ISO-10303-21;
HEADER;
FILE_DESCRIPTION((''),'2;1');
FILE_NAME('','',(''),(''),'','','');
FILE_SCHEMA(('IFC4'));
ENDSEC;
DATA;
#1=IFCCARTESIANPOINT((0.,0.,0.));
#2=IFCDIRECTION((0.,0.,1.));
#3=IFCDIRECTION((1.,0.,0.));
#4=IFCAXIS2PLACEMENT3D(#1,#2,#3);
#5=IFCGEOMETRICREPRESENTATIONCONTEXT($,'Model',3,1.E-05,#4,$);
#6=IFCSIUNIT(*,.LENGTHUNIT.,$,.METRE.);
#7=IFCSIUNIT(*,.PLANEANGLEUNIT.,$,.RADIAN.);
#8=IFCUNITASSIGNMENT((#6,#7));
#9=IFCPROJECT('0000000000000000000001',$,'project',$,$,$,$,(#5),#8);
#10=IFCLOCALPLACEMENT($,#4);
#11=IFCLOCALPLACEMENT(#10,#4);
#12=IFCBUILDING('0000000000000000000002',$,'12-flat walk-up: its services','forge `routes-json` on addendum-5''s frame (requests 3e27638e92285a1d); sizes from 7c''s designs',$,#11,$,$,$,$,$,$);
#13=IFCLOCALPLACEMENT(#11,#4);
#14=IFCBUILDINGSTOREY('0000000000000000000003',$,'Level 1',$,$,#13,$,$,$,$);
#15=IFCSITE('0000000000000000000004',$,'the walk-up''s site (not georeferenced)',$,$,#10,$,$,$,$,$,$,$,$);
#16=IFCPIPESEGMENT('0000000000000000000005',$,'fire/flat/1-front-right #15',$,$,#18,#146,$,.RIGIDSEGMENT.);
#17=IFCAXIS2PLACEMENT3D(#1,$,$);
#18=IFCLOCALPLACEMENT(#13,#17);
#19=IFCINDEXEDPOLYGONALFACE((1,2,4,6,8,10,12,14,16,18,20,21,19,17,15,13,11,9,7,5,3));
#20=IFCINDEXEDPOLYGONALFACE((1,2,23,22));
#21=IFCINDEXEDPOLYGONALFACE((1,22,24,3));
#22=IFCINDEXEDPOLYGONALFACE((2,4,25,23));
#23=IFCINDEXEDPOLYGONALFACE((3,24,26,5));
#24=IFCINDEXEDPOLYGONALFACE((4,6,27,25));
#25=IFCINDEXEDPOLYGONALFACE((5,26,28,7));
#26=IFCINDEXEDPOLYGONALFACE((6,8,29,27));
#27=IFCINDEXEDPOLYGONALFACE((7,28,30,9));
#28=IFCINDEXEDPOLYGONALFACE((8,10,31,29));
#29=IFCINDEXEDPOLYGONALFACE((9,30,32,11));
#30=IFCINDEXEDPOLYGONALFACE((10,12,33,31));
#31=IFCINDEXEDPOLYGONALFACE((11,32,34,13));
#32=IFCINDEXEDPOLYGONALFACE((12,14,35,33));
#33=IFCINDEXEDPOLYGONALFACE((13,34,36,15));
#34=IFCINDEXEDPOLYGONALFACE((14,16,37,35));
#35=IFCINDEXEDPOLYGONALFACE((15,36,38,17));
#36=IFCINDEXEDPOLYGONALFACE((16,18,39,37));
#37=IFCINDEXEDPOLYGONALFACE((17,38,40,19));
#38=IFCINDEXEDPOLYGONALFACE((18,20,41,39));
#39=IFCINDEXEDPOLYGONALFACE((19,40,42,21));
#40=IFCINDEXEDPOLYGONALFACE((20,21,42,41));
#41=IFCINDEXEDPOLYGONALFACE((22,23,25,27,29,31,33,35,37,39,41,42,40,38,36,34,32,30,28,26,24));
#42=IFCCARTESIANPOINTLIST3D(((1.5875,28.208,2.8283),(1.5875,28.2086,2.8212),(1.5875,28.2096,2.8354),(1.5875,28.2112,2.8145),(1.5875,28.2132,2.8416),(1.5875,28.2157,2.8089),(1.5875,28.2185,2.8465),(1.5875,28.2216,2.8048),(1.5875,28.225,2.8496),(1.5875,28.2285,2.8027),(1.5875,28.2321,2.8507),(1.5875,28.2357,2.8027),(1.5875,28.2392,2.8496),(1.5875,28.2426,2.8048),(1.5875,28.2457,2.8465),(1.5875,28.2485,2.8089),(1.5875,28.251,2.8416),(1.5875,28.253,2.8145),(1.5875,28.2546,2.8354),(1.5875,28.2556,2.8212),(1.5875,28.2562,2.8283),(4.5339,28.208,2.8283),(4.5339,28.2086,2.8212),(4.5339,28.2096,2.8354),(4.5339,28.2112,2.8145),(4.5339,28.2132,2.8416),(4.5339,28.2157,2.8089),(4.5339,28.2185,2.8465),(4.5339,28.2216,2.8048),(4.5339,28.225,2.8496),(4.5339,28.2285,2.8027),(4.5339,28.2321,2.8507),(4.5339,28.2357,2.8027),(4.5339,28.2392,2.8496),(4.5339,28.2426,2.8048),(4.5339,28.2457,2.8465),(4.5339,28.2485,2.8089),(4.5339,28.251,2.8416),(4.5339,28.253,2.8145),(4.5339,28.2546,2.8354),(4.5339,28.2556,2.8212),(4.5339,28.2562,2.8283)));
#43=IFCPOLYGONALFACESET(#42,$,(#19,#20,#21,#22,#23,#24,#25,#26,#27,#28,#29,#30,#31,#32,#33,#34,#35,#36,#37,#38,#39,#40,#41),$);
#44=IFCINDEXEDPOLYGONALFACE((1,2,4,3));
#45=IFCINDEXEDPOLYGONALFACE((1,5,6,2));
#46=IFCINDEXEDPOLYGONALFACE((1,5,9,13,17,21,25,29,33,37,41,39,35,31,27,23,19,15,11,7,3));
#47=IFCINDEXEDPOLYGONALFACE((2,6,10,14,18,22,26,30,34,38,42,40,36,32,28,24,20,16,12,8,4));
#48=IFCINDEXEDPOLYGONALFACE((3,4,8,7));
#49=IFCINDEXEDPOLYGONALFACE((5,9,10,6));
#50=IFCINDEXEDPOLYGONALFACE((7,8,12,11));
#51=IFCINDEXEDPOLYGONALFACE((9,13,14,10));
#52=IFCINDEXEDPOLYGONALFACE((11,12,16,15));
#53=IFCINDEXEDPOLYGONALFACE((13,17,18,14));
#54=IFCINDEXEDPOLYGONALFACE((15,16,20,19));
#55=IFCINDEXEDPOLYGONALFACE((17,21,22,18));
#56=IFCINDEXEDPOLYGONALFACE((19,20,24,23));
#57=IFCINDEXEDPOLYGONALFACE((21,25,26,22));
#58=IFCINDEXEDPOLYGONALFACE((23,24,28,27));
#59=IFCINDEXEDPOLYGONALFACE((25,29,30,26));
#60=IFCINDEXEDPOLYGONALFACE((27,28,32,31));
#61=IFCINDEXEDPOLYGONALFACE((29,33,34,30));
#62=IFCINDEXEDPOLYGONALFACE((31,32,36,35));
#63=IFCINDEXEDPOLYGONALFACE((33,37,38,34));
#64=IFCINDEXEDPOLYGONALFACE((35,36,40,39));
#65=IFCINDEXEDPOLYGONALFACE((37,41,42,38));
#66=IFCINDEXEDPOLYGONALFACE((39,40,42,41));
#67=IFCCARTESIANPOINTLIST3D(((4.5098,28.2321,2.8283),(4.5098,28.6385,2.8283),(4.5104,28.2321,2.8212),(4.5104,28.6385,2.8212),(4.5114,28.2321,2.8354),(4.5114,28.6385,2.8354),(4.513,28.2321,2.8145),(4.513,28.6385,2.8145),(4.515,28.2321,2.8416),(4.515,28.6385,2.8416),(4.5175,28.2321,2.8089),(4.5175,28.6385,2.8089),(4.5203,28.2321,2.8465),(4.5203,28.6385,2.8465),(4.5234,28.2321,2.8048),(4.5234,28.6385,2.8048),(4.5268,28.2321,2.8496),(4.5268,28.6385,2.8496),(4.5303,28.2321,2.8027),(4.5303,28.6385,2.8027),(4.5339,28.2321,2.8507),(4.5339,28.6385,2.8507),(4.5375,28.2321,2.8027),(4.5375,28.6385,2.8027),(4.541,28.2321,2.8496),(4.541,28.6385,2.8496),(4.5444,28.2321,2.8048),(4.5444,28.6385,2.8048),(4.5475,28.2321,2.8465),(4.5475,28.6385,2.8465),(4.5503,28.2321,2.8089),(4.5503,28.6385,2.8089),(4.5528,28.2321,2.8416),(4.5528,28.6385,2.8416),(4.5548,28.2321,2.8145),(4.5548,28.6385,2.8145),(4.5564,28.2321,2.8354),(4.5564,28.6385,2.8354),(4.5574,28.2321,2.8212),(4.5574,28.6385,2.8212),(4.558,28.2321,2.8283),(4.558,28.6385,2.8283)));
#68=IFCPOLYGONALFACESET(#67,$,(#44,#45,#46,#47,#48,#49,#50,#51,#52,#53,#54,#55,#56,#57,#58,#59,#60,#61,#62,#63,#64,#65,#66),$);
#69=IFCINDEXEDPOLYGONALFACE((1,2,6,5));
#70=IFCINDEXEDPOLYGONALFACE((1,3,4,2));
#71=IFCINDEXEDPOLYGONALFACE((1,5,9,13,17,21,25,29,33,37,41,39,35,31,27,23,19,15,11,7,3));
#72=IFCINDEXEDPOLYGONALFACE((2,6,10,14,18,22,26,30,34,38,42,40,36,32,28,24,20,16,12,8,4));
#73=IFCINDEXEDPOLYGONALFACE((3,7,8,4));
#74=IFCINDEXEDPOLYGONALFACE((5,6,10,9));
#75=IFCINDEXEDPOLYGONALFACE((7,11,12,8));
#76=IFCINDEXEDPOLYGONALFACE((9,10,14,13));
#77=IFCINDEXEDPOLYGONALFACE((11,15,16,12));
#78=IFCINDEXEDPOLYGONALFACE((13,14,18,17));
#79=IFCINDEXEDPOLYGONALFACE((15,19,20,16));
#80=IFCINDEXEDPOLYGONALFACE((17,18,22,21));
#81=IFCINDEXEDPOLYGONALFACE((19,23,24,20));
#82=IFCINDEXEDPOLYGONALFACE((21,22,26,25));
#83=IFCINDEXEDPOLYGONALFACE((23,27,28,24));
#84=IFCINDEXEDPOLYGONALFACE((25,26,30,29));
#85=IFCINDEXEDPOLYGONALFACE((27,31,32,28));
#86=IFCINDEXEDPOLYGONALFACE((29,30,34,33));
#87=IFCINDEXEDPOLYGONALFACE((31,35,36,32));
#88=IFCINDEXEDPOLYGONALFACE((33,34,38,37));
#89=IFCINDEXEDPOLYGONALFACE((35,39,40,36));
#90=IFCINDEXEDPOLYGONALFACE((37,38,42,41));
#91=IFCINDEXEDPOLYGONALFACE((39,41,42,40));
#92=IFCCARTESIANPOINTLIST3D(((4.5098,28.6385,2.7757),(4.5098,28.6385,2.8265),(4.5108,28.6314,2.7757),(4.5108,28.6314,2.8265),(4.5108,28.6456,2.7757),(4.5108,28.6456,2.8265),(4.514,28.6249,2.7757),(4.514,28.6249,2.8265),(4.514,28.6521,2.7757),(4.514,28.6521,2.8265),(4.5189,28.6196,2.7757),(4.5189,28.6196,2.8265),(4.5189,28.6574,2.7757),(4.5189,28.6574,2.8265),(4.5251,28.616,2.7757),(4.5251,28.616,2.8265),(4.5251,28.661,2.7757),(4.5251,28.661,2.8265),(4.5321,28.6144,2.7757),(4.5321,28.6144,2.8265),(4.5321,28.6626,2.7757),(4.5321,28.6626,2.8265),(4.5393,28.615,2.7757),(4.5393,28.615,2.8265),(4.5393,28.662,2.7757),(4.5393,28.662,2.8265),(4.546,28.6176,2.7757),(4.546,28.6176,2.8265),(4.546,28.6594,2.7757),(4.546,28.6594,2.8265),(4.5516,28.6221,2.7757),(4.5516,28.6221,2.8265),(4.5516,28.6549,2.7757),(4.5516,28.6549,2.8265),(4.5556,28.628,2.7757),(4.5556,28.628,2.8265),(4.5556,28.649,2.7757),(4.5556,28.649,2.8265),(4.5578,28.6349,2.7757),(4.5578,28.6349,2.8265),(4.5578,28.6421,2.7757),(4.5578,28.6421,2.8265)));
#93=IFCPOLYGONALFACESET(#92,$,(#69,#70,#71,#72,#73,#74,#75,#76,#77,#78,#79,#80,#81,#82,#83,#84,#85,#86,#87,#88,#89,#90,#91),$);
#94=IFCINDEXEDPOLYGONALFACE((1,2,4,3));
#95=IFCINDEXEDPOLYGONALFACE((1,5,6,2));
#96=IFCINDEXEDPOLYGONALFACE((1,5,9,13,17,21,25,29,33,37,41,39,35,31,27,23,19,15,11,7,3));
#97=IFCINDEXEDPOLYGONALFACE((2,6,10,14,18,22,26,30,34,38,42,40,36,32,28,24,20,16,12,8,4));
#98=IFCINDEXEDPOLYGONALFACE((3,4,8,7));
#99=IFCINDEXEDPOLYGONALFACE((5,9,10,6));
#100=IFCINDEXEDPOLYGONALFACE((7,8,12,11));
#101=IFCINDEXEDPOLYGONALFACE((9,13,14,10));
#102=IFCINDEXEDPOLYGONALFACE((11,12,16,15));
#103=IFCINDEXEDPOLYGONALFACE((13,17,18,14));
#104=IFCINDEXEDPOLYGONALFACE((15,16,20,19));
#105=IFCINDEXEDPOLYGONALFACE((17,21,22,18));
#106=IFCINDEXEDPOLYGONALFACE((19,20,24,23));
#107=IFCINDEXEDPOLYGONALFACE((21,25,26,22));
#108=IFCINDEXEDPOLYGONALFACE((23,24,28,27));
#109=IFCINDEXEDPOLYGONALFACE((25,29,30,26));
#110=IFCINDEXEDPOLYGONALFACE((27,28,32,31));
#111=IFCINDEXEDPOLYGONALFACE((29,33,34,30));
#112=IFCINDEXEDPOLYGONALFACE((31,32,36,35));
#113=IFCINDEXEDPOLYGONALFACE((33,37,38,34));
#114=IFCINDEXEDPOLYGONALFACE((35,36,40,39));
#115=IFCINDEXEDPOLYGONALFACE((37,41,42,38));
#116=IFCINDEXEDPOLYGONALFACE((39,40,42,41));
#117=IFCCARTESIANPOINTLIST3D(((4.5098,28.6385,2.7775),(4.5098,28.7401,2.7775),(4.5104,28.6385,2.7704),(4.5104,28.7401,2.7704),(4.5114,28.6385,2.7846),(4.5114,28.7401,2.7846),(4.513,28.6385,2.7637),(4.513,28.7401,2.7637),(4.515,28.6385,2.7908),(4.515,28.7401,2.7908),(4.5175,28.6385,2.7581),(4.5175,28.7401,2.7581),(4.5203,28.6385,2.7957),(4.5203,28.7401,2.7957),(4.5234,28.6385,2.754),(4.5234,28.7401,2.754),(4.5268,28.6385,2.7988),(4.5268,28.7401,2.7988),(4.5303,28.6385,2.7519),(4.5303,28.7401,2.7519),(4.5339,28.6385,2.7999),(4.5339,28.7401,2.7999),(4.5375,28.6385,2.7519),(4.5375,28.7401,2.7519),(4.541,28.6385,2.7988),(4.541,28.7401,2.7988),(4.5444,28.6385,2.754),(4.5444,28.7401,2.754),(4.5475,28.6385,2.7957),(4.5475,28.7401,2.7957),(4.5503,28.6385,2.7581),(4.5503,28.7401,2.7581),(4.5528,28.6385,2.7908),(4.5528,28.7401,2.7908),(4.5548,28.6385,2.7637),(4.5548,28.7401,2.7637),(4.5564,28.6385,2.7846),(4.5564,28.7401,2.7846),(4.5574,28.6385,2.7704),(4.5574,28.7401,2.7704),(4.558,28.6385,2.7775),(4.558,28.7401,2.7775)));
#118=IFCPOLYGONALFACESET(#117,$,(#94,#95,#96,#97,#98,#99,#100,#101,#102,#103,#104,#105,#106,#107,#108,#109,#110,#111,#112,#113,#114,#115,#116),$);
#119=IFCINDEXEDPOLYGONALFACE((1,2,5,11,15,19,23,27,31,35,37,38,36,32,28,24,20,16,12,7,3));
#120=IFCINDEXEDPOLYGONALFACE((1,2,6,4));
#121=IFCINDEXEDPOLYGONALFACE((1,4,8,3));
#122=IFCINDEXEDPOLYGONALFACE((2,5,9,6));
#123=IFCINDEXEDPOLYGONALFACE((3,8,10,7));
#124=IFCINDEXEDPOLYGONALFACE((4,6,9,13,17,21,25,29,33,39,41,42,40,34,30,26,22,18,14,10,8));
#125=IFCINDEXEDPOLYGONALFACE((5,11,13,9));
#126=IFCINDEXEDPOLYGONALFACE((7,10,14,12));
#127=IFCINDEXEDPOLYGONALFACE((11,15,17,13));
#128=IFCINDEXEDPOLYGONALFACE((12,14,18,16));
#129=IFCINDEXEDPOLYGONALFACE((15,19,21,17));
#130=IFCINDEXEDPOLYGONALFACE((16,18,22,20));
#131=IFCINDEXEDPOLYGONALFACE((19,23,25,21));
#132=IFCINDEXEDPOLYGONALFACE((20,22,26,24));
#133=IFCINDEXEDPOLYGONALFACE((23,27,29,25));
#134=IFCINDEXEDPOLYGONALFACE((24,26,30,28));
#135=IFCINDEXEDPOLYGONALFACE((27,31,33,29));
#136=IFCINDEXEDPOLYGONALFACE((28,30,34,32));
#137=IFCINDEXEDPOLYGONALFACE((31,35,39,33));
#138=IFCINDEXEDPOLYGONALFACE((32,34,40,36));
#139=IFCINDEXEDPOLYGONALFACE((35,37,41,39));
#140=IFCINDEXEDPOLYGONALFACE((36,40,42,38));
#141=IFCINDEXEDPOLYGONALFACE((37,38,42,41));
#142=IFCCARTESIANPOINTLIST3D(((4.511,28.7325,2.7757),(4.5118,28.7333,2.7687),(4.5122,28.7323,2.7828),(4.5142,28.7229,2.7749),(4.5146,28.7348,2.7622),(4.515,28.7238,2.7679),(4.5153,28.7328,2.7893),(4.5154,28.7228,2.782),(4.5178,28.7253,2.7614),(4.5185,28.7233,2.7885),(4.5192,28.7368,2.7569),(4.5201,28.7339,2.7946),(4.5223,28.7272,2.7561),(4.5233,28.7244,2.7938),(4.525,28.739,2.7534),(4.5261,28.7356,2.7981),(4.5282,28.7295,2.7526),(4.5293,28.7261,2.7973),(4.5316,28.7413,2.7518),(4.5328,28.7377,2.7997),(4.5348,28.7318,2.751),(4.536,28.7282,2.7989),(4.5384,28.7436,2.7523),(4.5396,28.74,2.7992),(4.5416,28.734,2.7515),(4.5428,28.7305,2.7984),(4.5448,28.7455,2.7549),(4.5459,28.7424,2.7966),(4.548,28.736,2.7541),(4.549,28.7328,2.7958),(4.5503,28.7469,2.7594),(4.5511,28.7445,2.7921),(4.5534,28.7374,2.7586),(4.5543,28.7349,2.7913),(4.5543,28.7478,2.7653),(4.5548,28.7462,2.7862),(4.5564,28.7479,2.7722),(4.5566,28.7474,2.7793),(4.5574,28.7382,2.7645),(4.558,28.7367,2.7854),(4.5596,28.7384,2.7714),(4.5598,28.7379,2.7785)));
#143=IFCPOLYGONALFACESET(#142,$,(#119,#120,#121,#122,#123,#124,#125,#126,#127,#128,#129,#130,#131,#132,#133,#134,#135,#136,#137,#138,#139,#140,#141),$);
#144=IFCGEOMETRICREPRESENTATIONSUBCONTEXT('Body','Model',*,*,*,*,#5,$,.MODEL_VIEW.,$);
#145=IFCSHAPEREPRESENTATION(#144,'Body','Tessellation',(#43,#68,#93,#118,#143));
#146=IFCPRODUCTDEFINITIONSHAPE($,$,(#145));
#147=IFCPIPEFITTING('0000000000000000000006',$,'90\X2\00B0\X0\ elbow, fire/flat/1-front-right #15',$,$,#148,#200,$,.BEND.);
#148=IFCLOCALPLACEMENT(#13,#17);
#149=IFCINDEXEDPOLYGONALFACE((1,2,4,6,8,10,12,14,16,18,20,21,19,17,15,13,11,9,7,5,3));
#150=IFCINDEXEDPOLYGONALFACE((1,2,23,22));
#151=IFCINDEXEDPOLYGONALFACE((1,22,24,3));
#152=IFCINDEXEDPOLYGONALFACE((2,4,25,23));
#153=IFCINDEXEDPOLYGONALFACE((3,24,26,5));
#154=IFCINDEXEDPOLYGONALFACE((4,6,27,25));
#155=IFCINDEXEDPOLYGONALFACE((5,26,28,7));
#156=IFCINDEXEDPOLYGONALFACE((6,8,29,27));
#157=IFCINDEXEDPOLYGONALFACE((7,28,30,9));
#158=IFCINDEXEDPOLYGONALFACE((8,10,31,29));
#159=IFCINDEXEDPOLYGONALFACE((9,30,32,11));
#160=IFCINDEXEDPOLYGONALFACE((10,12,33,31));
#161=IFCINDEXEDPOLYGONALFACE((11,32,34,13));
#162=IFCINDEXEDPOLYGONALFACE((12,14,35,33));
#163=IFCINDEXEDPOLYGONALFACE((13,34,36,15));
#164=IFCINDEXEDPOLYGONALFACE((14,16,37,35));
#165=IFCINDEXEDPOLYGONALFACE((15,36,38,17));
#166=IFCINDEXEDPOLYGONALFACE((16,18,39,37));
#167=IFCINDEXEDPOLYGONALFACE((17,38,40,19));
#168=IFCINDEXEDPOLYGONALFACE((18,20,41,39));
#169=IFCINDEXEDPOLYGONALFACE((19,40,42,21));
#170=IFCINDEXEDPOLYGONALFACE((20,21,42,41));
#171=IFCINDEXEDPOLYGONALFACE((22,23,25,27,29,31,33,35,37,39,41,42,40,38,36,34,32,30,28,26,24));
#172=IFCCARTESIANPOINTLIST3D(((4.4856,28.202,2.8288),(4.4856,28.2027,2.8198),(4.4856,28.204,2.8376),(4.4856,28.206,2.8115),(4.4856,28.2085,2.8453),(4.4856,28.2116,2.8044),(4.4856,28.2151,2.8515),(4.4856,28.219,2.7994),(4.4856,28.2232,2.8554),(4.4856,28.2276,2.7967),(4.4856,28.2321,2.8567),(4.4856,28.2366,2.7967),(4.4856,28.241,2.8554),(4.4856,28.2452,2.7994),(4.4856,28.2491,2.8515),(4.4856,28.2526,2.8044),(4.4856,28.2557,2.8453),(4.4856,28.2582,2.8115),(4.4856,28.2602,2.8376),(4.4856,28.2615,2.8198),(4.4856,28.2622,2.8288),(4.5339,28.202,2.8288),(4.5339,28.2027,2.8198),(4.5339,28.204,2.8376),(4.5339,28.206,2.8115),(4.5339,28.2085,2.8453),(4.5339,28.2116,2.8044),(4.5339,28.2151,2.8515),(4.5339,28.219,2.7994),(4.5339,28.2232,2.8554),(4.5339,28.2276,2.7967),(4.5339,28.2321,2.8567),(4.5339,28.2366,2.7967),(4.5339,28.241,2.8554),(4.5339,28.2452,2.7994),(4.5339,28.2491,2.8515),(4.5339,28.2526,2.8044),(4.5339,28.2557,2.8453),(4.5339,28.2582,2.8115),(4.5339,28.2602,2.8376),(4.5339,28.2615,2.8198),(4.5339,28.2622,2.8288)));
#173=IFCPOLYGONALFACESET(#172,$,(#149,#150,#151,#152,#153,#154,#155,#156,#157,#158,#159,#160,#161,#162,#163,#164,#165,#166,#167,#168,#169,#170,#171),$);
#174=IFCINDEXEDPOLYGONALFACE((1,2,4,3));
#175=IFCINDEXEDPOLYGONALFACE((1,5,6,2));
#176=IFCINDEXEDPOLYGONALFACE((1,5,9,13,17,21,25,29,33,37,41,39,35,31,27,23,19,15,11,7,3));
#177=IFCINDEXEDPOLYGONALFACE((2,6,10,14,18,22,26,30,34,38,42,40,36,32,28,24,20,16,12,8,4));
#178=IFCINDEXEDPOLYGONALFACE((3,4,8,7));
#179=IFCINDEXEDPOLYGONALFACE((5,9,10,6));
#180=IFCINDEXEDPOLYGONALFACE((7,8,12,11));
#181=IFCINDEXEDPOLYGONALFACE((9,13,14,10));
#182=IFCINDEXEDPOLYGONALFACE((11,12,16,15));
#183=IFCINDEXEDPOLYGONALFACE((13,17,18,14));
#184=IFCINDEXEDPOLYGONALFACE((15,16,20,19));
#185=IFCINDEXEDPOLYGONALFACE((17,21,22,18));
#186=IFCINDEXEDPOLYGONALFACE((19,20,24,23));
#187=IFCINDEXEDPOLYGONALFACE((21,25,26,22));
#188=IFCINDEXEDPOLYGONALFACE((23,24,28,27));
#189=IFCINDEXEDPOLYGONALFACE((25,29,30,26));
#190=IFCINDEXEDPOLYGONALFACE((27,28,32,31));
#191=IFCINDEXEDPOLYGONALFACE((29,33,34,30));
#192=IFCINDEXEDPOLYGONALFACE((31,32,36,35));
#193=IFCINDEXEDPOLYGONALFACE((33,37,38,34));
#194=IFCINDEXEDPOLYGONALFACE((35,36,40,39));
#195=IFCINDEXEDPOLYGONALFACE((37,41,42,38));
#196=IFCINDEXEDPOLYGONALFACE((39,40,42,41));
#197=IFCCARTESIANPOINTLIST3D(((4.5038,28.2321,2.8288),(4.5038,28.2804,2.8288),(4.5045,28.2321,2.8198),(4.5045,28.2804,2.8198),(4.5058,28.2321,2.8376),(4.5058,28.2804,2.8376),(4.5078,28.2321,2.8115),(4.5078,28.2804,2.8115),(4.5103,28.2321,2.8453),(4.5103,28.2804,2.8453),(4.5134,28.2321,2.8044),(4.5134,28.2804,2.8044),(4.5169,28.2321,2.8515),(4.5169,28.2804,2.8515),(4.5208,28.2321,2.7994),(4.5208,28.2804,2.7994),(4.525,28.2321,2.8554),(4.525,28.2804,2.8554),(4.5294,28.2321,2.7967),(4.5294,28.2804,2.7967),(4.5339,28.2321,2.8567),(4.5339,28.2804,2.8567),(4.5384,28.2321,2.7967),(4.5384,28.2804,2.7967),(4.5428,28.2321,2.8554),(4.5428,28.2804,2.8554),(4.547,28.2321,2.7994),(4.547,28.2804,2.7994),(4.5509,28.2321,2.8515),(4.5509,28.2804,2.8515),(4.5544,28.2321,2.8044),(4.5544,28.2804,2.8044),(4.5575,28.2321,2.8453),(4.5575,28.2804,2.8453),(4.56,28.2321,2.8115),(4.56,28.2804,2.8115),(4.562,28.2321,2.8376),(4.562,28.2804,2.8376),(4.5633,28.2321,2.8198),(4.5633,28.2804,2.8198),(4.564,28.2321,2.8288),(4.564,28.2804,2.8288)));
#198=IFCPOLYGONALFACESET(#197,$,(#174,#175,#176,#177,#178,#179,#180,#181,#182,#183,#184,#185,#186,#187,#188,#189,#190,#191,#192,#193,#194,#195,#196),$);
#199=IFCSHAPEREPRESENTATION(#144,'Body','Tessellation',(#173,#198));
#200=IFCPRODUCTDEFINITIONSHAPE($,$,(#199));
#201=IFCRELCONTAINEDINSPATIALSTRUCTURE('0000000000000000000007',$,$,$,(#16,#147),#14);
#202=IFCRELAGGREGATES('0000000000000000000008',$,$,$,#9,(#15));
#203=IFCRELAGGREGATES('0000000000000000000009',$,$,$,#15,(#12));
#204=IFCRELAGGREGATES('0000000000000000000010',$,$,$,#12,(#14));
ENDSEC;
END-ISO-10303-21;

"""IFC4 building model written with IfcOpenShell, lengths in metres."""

from ifc_helpers import new_model, entity, si_unit, frame, origin_with_axes, place, context, subcontext, project, spatial, element, save


model = new_model("IFC4")

# Units and contexts
model_context = context("Model", 3, precision=1e-05, world=origin_with_axes())
body_context = subcontext(model_context, "Body", "Model", "MODEL_VIEW")
ifc_project = project(units=[si_unit("LENGTHUNIT", "METRE"), si_unit("PLANEANGLEUNIT", "RADIAN")], contexts=[model_context])

# Site, building, storey
site_placement = place(None, origin_with_axes())
site = spatial("IfcSite", under=ifc_project, at=site_placement, Name="the walk-up's site (not georeferenced)")
building_placement = place(site_placement, origin_with_axes())
building = spatial("IfcBuilding", under=site, at=building_placement, Name="12-flat walk-up: its services", Description="forge `routes-json` on addendum-5's frame (requests 3e27638e92285a1d); sizes from 7c's designs")
storey_placement = place(building_placement, origin_with_axes())
storey = spatial("IfcBuildingStorey", under=building, at=storey_placement, Name="Level 1")

# Pipe segment
pipe_segment_1_placement = place(storey_placement, frame((1.5875, 28.2321, 2.8265), z_axis=(0.0, 0.0, 1.0), x_axis=(1.0, 0.0, 0.0)))
element("IfcPipeSegment", 1, at=pipe_segment_1_placement, inside=storey, Name="fire/flat/1-front-right #15", PredefinedType="RIGIDSEGMENT", context=body_context, shape_type="AdvancedSweptSolid", body=[
    entity("IfcSweptDiskSolid", entity("IfcPolyline", [entity("IfcCartesianPoint", [0.0, 0.0, 0.0]), entity("IfcCartesianPoint", [2.9464, 0.0, 0.0])]), 0.0241),
    entity("IfcSweptDiskSolid", entity("IfcPolyline", [entity("IfcCartesianPoint", [2.9464, 0.0, 0.0]), entity("IfcCartesianPoint", [2.9464, 0.4064, 0.0])]), 0.0241),
    entity("IfcSweptDiskSolid", entity("IfcPolyline", [entity("IfcCartesianPoint", [2.9464, 0.4064, 0.0]), entity("IfcCartesianPoint", [2.9464, 0.4064, -0.0508])]), 0.0241),
    entity("IfcSweptDiskSolid", entity("IfcPolyline", [entity("IfcCartesianPoint", [2.9464, 0.4064, -0.0508]), entity("IfcCartesianPoint", [2.9464, 0.508, -0.0508])]), 0.0241),
    entity("IfcSweptDiskSolid", entity("IfcPolyline", [entity("IfcCartesianPoint", [2.9464, 0.508, -0.0508]), entity("IfcCartesianPoint", [2.9496, 0.4985, -0.0516])]), 0.0241),
])

# Pipe fitting
pipe_fitting_1_placement = place(storey_placement, frame((4.4856, 28.2321, 2.8265), z_axis=(0.0, 0.0, 1.0), x_axis=(1.0, 0.0, 0.0)))
element("IfcPipeFitting", 2, at=pipe_fitting_1_placement, inside=storey, Name="90° elbow, fire/flat/1-front-right #15", PredefinedType="BEND", context=body_context, shape_type="AdvancedSweptSolid", body=[
    entity("IfcSweptDiskSolid", entity("IfcPolyline", [entity("IfcCartesianPoint", [0.0, 0.0, 0.0]), entity("IfcCartesianPoint", [0.0483, 0.0, 0.0])]), 0.0302),
    entity("IfcSweptDiskSolid", entity("IfcPolyline", [entity("IfcCartesianPoint", [0.0483, 0.0, 0.0]), entity("IfcCartesianPoint", [0.0483, 0.0483, 0.0])]), 0.0302),
])

save(model, "model.ifc")
